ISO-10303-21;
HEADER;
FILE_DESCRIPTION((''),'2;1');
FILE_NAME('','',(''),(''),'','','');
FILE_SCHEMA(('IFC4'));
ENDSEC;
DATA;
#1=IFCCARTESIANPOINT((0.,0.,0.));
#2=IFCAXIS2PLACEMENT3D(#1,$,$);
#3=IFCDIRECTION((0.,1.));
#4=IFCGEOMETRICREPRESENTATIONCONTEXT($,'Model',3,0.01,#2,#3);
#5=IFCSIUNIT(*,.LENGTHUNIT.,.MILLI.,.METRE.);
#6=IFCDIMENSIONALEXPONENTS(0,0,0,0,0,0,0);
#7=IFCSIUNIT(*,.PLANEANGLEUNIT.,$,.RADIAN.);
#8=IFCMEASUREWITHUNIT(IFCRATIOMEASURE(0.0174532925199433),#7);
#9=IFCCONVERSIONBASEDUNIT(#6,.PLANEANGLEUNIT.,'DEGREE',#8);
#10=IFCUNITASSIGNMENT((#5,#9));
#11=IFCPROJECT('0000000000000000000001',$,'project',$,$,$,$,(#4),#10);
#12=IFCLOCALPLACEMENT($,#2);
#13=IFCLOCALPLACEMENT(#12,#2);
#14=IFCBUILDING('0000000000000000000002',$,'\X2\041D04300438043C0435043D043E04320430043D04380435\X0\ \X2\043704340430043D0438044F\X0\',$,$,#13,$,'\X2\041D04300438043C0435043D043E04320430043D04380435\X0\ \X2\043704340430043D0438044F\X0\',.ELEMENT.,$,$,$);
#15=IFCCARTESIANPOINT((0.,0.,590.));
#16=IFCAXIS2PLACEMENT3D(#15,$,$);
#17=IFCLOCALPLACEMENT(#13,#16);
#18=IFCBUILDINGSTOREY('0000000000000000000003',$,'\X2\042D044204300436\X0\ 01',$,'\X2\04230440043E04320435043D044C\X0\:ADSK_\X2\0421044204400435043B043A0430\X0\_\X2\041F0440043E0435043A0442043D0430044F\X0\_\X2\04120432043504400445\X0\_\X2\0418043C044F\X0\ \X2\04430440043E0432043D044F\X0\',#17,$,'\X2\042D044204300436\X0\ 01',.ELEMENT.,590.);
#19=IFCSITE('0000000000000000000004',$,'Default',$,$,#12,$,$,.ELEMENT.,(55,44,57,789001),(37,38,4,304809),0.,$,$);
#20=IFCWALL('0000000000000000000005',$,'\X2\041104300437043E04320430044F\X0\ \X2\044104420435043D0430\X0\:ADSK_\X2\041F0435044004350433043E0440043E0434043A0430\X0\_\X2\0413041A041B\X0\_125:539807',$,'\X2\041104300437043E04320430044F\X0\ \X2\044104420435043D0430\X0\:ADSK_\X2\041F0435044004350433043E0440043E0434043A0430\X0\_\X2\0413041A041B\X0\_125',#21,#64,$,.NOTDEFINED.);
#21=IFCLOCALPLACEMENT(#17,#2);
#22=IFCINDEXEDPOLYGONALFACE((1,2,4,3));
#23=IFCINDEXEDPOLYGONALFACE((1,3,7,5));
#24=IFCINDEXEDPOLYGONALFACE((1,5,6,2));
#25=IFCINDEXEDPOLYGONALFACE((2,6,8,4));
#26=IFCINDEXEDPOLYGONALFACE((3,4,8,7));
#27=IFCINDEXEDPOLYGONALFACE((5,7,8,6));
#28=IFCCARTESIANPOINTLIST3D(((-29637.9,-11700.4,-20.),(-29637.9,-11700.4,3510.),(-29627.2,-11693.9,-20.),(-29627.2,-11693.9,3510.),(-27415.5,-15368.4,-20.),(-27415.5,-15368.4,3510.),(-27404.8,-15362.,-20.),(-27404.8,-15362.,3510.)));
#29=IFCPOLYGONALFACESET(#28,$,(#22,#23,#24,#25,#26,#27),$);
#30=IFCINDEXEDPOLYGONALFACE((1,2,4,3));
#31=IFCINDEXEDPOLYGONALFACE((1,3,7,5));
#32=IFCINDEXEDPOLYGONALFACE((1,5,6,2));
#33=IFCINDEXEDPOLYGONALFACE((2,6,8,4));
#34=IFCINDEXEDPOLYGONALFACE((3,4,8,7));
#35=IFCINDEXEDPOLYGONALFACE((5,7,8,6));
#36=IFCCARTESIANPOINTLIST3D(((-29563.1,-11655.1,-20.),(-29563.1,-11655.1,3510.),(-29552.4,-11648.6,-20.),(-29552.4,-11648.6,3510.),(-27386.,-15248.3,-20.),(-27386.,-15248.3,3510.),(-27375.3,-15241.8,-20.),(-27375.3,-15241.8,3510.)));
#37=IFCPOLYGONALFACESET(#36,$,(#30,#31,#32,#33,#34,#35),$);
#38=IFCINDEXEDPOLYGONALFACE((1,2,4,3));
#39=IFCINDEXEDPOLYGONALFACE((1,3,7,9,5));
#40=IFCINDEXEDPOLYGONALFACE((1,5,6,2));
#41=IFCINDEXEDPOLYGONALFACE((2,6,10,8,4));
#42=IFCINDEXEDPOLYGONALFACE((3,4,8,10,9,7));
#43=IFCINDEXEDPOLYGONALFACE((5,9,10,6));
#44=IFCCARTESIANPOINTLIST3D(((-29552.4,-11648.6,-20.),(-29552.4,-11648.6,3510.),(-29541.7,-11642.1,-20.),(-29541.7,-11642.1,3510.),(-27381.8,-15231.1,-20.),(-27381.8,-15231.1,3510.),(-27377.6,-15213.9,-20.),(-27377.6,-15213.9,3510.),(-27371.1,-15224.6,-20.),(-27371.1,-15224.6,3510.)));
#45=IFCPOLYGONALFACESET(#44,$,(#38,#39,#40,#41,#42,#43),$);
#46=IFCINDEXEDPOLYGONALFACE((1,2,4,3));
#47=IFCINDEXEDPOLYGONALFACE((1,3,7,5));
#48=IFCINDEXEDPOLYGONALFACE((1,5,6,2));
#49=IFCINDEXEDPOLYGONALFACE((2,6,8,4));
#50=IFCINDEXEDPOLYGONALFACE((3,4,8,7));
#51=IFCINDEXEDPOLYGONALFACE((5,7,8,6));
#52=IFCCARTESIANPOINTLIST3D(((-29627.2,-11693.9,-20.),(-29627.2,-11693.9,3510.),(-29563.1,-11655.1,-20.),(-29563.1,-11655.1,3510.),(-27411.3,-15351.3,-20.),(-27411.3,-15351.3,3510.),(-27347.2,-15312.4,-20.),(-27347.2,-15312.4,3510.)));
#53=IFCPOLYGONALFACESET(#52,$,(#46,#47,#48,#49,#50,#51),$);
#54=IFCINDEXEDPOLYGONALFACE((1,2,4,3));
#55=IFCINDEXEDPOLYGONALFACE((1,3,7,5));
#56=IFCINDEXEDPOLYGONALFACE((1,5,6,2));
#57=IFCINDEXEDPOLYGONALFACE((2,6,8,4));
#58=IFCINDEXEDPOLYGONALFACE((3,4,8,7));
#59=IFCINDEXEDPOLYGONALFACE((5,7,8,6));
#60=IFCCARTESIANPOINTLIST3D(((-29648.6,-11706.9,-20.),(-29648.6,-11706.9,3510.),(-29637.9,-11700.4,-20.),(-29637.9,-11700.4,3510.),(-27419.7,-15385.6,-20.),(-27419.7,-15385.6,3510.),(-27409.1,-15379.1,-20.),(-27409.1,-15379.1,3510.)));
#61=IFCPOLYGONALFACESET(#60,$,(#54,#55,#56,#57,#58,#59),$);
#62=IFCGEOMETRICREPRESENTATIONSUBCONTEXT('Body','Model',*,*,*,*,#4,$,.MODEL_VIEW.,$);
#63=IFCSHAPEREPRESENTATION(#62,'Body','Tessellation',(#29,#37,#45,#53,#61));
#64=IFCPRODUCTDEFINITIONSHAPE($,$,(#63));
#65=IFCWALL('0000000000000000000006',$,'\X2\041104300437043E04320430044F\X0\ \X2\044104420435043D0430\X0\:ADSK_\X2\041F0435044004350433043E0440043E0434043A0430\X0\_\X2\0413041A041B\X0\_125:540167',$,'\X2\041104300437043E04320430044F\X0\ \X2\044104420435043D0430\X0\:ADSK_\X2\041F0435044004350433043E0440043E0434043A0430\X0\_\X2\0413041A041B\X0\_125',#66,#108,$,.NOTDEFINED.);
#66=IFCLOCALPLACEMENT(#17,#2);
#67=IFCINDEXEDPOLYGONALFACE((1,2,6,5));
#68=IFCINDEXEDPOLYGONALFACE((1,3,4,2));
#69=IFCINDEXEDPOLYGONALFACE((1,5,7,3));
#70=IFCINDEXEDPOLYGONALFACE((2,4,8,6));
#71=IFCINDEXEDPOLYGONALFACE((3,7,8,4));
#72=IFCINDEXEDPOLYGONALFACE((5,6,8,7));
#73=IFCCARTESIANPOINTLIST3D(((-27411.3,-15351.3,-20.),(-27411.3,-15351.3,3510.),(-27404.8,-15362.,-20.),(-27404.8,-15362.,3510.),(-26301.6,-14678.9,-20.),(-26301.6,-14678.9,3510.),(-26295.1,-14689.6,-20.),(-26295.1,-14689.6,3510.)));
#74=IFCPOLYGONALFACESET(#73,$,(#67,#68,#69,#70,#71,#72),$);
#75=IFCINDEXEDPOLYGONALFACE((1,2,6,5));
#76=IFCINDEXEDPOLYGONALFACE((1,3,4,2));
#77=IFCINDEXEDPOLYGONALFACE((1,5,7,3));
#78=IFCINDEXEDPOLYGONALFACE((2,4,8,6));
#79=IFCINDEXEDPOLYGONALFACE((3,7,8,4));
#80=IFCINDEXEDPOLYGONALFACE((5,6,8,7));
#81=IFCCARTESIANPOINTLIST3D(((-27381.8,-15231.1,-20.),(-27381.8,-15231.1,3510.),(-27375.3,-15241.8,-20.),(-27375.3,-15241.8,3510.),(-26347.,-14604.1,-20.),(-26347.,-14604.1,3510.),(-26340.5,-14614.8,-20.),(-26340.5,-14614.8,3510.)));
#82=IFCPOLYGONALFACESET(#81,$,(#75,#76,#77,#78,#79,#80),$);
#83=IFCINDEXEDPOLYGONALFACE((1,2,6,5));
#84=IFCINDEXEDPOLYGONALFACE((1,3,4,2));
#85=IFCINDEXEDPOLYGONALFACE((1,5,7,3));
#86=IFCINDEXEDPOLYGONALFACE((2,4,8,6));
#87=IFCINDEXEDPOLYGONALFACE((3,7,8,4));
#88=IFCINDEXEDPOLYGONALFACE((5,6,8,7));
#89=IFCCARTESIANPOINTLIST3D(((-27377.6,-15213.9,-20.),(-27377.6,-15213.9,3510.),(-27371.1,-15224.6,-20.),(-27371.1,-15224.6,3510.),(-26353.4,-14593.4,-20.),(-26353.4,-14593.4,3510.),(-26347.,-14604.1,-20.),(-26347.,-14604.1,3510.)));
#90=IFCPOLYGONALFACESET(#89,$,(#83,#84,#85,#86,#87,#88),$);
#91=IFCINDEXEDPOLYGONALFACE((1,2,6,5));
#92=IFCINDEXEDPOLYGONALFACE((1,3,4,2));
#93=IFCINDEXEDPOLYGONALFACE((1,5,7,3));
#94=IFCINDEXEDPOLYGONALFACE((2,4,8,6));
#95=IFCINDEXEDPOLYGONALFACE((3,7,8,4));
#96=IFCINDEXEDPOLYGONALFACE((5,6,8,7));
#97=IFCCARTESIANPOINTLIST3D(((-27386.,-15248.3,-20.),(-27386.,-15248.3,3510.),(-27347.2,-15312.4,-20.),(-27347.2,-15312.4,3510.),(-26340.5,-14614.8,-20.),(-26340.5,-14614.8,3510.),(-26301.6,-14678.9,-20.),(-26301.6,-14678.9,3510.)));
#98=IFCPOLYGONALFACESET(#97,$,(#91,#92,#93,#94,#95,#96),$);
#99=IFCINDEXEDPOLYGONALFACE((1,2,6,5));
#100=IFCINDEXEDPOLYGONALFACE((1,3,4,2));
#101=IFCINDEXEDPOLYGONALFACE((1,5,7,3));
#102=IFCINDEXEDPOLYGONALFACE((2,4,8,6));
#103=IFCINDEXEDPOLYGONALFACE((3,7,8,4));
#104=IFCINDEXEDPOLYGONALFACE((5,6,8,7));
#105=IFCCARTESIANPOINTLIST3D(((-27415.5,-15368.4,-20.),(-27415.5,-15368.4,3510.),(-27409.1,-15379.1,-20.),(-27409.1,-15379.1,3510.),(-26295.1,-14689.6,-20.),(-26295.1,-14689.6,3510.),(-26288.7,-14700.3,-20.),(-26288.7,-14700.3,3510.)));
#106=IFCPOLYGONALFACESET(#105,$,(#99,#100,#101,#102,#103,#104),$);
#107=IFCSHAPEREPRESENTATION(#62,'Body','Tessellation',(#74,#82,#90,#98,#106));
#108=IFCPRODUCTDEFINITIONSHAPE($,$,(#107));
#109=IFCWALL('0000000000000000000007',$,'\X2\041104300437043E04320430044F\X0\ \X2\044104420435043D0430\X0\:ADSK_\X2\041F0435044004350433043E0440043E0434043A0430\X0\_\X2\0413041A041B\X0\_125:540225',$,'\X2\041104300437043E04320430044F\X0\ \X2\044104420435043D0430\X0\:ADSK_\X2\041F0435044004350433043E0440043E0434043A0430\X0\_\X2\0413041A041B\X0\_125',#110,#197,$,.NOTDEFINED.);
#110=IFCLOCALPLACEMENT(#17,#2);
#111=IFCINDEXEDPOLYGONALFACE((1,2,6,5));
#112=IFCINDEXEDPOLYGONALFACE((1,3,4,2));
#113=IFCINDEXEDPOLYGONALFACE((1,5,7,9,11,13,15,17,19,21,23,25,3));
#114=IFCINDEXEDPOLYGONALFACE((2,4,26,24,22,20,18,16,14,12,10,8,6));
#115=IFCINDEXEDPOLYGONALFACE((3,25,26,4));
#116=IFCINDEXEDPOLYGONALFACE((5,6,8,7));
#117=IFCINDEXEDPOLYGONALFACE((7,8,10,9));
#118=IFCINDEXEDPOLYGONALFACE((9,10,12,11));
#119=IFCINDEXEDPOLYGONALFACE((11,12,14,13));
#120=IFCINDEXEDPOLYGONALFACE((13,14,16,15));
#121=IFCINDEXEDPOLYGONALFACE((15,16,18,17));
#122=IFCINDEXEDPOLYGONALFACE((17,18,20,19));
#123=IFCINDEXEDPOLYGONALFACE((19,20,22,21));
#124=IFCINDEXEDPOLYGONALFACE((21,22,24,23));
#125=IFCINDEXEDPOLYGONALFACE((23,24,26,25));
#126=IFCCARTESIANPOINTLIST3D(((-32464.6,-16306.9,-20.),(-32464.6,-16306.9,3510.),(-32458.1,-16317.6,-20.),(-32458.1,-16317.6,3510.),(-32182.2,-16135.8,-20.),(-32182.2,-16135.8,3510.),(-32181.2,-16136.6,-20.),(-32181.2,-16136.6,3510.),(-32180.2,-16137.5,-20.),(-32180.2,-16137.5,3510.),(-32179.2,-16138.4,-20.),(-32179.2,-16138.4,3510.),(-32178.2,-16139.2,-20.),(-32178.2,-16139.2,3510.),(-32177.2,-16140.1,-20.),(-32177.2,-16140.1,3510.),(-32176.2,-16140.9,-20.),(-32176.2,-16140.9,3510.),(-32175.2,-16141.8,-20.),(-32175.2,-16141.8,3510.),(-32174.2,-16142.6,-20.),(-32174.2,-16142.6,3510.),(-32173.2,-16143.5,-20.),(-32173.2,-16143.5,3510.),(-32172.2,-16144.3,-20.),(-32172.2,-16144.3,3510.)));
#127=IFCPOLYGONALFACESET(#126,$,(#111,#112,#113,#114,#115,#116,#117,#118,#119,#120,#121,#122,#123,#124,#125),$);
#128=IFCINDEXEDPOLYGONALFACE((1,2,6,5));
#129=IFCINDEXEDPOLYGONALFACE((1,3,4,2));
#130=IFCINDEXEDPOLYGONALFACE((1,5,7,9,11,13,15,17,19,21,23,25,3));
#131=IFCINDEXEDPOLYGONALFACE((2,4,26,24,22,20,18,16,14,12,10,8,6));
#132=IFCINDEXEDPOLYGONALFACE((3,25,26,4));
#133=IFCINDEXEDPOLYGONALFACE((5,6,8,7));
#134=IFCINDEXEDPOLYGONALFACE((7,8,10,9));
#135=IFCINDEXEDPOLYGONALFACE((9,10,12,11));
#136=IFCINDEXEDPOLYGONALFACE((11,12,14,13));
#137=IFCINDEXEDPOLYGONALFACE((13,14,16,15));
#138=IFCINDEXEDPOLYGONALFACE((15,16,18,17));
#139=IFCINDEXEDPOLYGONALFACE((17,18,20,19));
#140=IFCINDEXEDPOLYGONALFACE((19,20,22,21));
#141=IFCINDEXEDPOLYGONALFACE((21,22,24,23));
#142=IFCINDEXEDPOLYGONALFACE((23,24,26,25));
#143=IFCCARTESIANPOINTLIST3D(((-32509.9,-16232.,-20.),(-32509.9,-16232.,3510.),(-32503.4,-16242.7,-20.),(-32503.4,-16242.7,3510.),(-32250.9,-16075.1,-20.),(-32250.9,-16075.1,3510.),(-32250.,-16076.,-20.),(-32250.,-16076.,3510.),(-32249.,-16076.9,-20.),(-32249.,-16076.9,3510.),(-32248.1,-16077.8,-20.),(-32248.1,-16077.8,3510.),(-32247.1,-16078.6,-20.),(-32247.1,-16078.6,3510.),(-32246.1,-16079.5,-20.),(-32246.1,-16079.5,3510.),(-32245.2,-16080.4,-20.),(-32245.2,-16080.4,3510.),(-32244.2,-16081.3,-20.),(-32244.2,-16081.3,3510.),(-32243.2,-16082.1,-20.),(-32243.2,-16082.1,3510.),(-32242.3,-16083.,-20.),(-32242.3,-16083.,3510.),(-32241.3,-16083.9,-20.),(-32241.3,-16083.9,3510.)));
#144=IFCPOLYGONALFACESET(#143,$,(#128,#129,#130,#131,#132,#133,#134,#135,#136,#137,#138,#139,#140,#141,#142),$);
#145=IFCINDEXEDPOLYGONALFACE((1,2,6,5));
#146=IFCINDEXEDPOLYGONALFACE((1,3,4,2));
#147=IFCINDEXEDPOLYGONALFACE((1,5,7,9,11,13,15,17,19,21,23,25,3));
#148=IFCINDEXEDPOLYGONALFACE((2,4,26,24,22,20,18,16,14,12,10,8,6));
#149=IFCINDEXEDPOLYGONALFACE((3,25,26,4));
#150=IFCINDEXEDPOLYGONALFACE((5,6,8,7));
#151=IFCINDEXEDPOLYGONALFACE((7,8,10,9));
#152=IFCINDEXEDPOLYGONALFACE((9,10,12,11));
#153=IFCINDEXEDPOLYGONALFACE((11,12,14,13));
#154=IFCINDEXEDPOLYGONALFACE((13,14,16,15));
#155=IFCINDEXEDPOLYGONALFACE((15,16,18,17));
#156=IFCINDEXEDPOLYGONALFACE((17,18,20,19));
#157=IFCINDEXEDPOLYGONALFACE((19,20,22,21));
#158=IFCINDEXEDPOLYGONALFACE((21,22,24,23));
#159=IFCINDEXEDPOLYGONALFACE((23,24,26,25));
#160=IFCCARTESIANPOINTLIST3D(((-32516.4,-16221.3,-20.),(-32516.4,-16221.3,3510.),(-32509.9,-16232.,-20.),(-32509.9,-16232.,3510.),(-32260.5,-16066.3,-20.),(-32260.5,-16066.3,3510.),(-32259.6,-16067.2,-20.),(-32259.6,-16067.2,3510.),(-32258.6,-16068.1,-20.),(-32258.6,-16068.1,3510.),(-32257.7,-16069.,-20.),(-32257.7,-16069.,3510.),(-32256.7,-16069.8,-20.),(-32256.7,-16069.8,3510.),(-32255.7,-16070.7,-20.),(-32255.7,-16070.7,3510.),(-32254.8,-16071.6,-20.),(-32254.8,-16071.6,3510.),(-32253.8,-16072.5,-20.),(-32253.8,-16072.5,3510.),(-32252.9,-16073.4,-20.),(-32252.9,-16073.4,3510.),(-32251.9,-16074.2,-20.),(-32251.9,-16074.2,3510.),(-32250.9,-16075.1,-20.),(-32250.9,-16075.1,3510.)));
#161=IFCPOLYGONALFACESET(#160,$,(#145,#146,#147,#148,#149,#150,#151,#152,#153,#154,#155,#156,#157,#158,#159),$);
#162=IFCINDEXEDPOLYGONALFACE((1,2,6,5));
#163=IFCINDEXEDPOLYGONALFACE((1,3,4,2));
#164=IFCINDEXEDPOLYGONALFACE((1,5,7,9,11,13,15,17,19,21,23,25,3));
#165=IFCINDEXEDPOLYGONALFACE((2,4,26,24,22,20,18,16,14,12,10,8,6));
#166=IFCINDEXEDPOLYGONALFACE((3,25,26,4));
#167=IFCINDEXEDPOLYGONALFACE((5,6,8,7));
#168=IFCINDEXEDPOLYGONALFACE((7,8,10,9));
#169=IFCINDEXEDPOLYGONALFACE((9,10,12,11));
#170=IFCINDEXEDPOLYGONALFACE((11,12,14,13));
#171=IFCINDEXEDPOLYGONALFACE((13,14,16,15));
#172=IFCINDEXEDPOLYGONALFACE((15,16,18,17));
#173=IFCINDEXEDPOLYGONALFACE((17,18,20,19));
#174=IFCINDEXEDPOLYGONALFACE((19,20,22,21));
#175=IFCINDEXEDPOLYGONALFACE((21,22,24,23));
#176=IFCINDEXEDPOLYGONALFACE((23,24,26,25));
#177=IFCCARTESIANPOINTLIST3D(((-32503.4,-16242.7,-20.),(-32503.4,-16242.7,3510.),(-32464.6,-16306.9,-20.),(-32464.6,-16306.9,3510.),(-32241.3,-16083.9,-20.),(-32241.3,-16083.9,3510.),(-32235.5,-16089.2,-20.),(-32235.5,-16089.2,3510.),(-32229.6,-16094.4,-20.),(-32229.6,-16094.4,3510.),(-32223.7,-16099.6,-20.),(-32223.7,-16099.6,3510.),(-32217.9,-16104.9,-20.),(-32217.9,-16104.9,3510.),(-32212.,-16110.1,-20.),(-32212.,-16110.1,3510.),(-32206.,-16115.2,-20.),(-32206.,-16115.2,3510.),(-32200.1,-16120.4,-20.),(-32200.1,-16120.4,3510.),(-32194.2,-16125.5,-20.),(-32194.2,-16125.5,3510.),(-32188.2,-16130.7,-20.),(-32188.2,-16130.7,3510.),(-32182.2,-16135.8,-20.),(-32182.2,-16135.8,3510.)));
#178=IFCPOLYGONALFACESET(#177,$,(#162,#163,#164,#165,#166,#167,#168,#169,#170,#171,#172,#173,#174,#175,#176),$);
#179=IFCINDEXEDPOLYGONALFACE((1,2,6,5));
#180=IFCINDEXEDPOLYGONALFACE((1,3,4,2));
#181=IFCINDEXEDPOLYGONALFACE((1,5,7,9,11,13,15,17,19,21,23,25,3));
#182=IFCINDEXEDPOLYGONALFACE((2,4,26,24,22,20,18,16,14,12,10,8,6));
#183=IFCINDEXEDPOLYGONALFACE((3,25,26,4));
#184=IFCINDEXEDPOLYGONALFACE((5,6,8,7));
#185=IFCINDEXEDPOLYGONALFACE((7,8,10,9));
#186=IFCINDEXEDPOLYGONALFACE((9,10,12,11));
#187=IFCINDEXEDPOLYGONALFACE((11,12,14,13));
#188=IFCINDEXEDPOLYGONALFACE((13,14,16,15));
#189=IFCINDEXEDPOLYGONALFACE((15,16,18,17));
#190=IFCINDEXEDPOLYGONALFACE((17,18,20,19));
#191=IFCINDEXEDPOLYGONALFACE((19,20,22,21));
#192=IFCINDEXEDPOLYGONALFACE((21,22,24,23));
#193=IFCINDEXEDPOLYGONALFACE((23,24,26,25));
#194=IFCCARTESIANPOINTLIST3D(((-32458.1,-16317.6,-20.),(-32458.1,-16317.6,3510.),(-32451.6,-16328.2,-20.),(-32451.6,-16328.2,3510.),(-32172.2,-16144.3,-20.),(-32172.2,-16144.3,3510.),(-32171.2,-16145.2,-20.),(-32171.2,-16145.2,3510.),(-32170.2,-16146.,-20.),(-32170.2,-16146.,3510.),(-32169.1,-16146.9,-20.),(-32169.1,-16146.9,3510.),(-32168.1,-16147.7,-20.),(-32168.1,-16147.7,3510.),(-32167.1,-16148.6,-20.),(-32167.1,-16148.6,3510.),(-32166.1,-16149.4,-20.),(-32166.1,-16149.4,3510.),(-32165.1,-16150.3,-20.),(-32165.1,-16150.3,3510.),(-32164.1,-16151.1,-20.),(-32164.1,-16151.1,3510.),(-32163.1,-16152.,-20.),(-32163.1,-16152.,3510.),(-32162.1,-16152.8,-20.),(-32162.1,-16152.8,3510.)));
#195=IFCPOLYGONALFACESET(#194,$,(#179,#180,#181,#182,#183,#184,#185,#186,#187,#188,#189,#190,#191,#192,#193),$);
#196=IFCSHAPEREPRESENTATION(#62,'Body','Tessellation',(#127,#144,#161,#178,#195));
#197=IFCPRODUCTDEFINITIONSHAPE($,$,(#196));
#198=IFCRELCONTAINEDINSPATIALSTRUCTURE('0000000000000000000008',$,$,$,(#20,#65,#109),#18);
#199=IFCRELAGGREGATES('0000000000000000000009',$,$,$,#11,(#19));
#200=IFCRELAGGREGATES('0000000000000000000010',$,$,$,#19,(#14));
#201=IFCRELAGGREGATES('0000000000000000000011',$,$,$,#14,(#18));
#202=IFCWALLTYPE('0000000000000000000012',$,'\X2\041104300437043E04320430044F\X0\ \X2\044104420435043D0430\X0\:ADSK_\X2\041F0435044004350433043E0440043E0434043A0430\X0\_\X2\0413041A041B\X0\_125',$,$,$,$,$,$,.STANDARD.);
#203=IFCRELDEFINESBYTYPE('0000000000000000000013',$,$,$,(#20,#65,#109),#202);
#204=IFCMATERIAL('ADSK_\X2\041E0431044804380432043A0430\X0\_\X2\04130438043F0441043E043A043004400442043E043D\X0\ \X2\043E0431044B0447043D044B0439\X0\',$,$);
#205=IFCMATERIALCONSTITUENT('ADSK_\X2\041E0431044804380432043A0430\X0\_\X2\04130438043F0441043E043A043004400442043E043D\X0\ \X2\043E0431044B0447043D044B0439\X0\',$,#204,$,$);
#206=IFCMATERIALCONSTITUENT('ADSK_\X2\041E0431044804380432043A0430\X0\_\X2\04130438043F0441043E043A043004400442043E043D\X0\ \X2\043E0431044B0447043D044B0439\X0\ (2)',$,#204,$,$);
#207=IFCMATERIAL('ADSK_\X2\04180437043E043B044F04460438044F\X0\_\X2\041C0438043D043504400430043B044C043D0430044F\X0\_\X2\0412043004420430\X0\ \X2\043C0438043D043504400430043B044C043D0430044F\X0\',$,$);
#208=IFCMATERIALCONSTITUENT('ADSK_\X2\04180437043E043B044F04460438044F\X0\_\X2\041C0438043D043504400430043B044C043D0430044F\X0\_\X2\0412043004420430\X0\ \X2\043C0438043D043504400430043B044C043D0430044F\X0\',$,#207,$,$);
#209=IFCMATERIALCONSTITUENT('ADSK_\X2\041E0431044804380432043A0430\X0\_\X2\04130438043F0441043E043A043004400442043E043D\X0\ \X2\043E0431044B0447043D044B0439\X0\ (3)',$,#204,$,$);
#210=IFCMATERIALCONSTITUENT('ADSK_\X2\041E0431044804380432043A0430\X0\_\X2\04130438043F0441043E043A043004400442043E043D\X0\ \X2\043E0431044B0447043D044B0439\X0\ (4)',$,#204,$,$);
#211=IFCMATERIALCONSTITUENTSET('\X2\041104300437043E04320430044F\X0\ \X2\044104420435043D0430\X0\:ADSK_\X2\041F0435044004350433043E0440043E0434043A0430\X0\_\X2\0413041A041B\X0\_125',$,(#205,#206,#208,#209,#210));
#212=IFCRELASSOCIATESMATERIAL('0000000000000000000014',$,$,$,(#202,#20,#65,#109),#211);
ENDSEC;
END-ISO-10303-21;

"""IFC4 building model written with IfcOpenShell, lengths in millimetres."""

from ifc_helpers import new_model, entity, si_unit, converted_unit, direction, frame, origin, place, context, subcontext, project, spatial, indexed_curve, outline, extrude, material, constituent, constituent_set, type_object, element, save


model = new_model("IFC4")

# Units and contexts
model_context = context("Model", 3, precision=0.01, world=origin(), true_north=direction((0.0, 1.0)))
body_context = subcontext(model_context, "Body", "Model", "MODEL_VIEW")
ifc_project = project(units=[si_unit("LENGTHUNIT", "METRE", prefix="MILLI"), converted_unit("PLANEANGLEUNIT", "DEGREE", entity("IfcRatioMeasure", 0.0174532925199433), si_unit("PLANEANGLEUNIT", "RADIAN"), dimensions=[0, 0, 0, 0, 0, 0, 0])], contexts=[model_context])

# Site, building, storey
site_placement = place(None, origin())
site = spatial("IfcSite", under=ifc_project, at=site_placement, Name="Default", CompositionType="ELEMENT", RefLatitude=(55, 44, 57, 789001), RefLongitude=(37, 38, 4, 304809), RefElevation=0.0)
building_placement = place(site_placement, origin())
building = spatial("IfcBuilding", under=site, at=building_placement, Name="Наименование здания", LongName="Наименование здания", CompositionType="ELEMENT")
storey_placement = place(building_placement, frame((0.0, 0.0, 590.0)))
storey = spatial("IfcBuildingStorey", under=building, at=storey_placement, Name="Этаж 01", ObjectType="Уровень:ADSK_Стрелка_Проектная_Вверх_Имя уровня", LongName="Этаж 01", CompositionType="ELEMENT", Elevation=590.0)

# Walls
ifc_material_1 = material(Name="ADSK_Обшивка_Гипсокартон обычный")
ifc_constituent_1 = constituent(ifc_material_1, Name="ADSK_Обшивка_Гипсокартон обычный")
ifc_constituent_2 = constituent(ifc_material_1, Name="ADSK_Обшивка_Гипсокартон обычный (2)")
ifc_material_2 = material(Name="ADSK_Изоляция_Минеральная_Вата минеральная")
ifc_constituent_3 = constituent(ifc_material_2, Name="ADSK_Изоляция_Минеральная_Вата минеральная")
ifc_constituent_4 = constituent(ifc_material_1, Name="ADSK_Обшивка_Гипсокартон обычный (3)")
ifc_constituent_5 = constituent(ifc_material_1, Name="ADSK_Обшивка_Гипсокартон обычный (4)")
ifc_constituent_set = constituent_set(constituents=[ifc_constituent_1, ifc_constituent_2, ifc_constituent_3, ifc_constituent_4, ifc_constituent_5], Name="Базовая стена:ADSK_Перегородка_ГКЛ_125")
wall_type_1 = type_object("IfcWallType", Name="Базовая стена:ADSK_Перегородка_ГКЛ_125", PredefinedType="STANDARD", material=ifc_constituent_set)
wall_1_placement = place(storey_placement, frame((-29595.1, -11674.5, -20.0), z_axis=(0.0, 0.0, 1.0), x_axis=(0.518188, -0.855267, 0.0)))
element("IfcWall", 1, at=wall_1_placement, inside=storey, type_object=wall_type_1, material=ifc_constituent_set, Name="Базовая стена:ADSK_Перегородка_ГКЛ_125:539807", ObjectType="Базовая стена:ADSK_Перегородка_ГКЛ_125", PredefinedType="NOTDEFINED", context=body_context, shape_type="SweptSolid", body=[
    extrude(outline(indexed_curve([(-6.2, -2144.4), (6.3, -2144.4), (6.2, 2144.4), (-6.3, 2144.4), (-6.2, -2144.4)], self_intersect=False)), frame((2144.4, -43.8, 0.0), z_axis=(0.0, 0.0, 1.0), x_axis=(0.0, 1.0, 0.0)), (0.0, 0.0, 1.0), 3530.0),
    extrude(outline(indexed_curve([(-6.3, -2100.6), (6.2, -2100.6), (6.3, 2100.6), (-6.2, 2100.6), (-6.3, -2100.6)], self_intersect=False)), frame((2100.6, 43.7, 0.0), z_axis=(0.0, 0.0, 1.0), x_axis=(0.0, 1.0, 0.0)), (0.0, 0.0, 1.0), 3530.0),
    extrude(outline(indexed_curve([(-1665.5, -5.0), (2510.7, -5.0), (2510.7, 7.5), (-1678.0, 7.5), (-1678.0, -5.0), (-1665.5, -5.0)], self_intersect=False)), frame((2510.7, 57.5, 0.0), z_axis=(0.0, 0.0, 1.0), x_axis=(-1.0, 0.0, 0.0)), (0.0, 0.0, 1.0), 3530.0),
    extrude(outline(indexed_curve([(-37.5, -2138.1), (37.5, -2138.1), (37.5, 2138.1), (-37.5, 2138.1), (-37.5, -2138.1)], self_intersect=False)), frame((2138.1, 0.0, 0.0), z_axis=(0.0, 0.0, 1.0), x_axis=(0.0, 1.0, 0.0)), (0.0, 0.0, 1.0), 3530.0),
    extrude(outline(indexed_curve([(-6.3, -2150.6), (6.2, -2150.6), (6.3, 2150.6), (-6.2, 2150.6), (-6.3, -2150.6)], self_intersect=False)), frame((2150.6, -56.3, 0.0), z_axis=(0.0, 0.0, 1.0), x_axis=(0.0, -1.0, 0.0)), (0.0, 0.0, 1.0), 3530.0),
])
wall_2_placement = place(storey_placement, frame((-27345.2, -15267.4, -20.0), z_axis=(0.0, 0.0, 1.0), x_axis=(0.855267, 0.518188, 0.0)))
element("IfcWall", 2, at=wall_2_placement, inside=storey, type_object=wall_type_1, material=ifc_constituent_set, Name="Базовая стена:ADSK_Перегородка_ГКЛ_125:540167", ObjectType="Базовая стена:ADSK_Перегородка_ГКЛ_125", PredefinedType="NOTDEFINED", context=body_context, shape_type="SweptSolid", body=[
    extrude(outline(indexed_curve([(-6.3, -648.7), (6.2, -648.7), (6.3, 648.7), (-6.2, 648.8), (-6.3, -648.7)], self_intersect=False)), frame((548.7, -43.7, 0.0), z_axis=(0.0, 0.0, 1.0), x_axis=(0.0, 1.0, 0.0)), (0.0, 0.0, 1.0), 3530.0),
    extrude(outline(indexed_curve([(-6.2, -605.0), (6.3, -605.0), (6.2, 605.0), (-6.3, 605.0), (-6.2, -605.0)], self_intersect=False)), frame((592.5, 43.8, 0.0), z_axis=(0.0, 0.0, 1.0), x_axis=(0.0, 1.0, 0.0)), (0.0, 0.0, 1.0), 3530.0),
    extrude(outline(indexed_curve([(-6.2, -598.8), (6.3, -598.8), (6.2, 598.8), (-6.3, 598.7), (-6.2, -598.8)], self_intersect=False)), frame((598.7, 56.2, 0.0), z_axis=(0.0, 0.0, 1.0), x_axis=(0.0, -1.0, 0.0)), (0.0, 0.0, 1.0), 3530.0),
    extrude(outline(indexed_curve([(-37.5, -611.2), (37.5, -611.2), (37.5, 611.2), (-37.5, 611.2), (-37.5, -611.2)], self_intersect=False)), frame((586.2, 0.0, 0.0), z_axis=(0.0, 0.0, 1.0), x_axis=(0.0, 1.0, 0.0)), (0.0, 0.0, 1.0), 3530.0),
    extrude(outline(indexed_curve([(-6.2, -655.0), (6.3, -655.0), (6.2, 655.0), (-6.3, 655.0), (-6.2, -655.0)], self_intersect=False)), frame((542.5, -56.2, 0.0), z_axis=(0.0, 0.0, 1.0), x_axis=(0.0, -1.0, 0.0)), (0.0, 0.0, 1.0), 3530.0),
])
wall_3_placement = place(storey_placement, frame((-32484.0, -16274.8, -20.0), z_axis=(0.0, 0.0, 1.0), x_axis=(0.855267, 0.518188, 0.0)))
element("IfcWall", 3, at=wall_3_placement, inside=storey, type_object=wall_type_1, material=ifc_constituent_set, Name="Базовая стена:ADSK_Перегородка_ГКЛ_125:540225", ObjectType="Базовая стена:ADSK_Перегородка_ГКЛ_125", PredefinedType="NOTDEFINED", context=body_context, shape_type="SweptSolid", body=[
    extrude(outline(indexed_curve([(-166.1, -6.2), (168.2, -6.2), (167.8, -5.0), (167.4, -3.8), (166.9, -2.5), (166.5, -1.3), (166.1, 0.0), (165.7, 1.2), (165.3, 2.5), (164.9, 3.7), (164.4, 5.0), (164.0, 6.2), (-166.1, 6.3), (-166.1, -6.2)], self_intersect=False)), frame((166.1, -43.8, 0.0)), (0.0, 0.0, 1.0), 3530.0),
    extrude(outline(indexed_curve([(-152.3, -6.2), (154.2, -6.2), (153.8, -5.0), (153.4, -3.8), (153.1, -2.5), (152.7, -1.3), (152.3, 0.0), (151.9, 1.2), (151.6, 2.5), (151.2, 3.7), (150.8, 5.0), (150.5, 6.2), (-152.3, 6.3), (-152.3, -6.2)], self_intersect=False)), frame((152.3, 43.7, 0.0)), (0.0, 0.0, 1.0), 3530.0),
    extrude(outline(indexed_curve([(-6.3, -150.5), (6.2, -150.5), (6.3, 152.3), (5.0, 151.9), (3.8, 151.6), (2.5, 151.2), (1.3, 150.8), (0.0, 150.5), (-1.2, 150.1), (-2.5, 149.8), (-3.7, 149.4), (-5.0, 149.0), (-6.3, 148.7), (-6.3, -150.5)], self_intersect=False)), frame((150.5, 56.2, 0.0), z_axis=(0.0, 0.0, 1.0), x_axis=(0.0, -1.0, 0.0)), (0.0, 0.0, 1.0), 3530.0),
    extrude(outline(indexed_curve([(-159.2, -37.5), (171.0, -37.5), (168.5, -30.0), (166.1, -22.6), (163.7, -15.1), (161.3, -7.6), (158.9, -0.1), (156.5, 7.4), (154.2, 14.9), (151.9, 22.4), (149.6, 30.0), (147.3, 37.5), (-159.2, 37.5), (-159.2, -37.5)], self_intersect=False)), frame((159.2, 0.0, 0.0)), (0.0, 0.0, 1.0), 3530.0),
    extrude(outline(indexed_curve([(-60.7, -159.3), (-59.4, -159.3), (-58.1, -159.3), (-56.7, -159.3), (-55.4, -159.3), (-54.1, -159.3), (-52.8, -159.3), (-51.5, -159.3), (-50.1, -159.3), (-48.8, -159.3), (-47.5, -159.3), (60.0, 157.3), (48.2, 161.3), (-60.7, -159.3)], self_intersect=False)), frame((168.2, -56.3, 0.0), z_axis=(0.0, 0.0, 1.0), x_axis=(-0.321596, 0.946877, 0.0)), (0.0, 0.0, 1.0), 3530.0),
])

save(model, "model.ifc")
